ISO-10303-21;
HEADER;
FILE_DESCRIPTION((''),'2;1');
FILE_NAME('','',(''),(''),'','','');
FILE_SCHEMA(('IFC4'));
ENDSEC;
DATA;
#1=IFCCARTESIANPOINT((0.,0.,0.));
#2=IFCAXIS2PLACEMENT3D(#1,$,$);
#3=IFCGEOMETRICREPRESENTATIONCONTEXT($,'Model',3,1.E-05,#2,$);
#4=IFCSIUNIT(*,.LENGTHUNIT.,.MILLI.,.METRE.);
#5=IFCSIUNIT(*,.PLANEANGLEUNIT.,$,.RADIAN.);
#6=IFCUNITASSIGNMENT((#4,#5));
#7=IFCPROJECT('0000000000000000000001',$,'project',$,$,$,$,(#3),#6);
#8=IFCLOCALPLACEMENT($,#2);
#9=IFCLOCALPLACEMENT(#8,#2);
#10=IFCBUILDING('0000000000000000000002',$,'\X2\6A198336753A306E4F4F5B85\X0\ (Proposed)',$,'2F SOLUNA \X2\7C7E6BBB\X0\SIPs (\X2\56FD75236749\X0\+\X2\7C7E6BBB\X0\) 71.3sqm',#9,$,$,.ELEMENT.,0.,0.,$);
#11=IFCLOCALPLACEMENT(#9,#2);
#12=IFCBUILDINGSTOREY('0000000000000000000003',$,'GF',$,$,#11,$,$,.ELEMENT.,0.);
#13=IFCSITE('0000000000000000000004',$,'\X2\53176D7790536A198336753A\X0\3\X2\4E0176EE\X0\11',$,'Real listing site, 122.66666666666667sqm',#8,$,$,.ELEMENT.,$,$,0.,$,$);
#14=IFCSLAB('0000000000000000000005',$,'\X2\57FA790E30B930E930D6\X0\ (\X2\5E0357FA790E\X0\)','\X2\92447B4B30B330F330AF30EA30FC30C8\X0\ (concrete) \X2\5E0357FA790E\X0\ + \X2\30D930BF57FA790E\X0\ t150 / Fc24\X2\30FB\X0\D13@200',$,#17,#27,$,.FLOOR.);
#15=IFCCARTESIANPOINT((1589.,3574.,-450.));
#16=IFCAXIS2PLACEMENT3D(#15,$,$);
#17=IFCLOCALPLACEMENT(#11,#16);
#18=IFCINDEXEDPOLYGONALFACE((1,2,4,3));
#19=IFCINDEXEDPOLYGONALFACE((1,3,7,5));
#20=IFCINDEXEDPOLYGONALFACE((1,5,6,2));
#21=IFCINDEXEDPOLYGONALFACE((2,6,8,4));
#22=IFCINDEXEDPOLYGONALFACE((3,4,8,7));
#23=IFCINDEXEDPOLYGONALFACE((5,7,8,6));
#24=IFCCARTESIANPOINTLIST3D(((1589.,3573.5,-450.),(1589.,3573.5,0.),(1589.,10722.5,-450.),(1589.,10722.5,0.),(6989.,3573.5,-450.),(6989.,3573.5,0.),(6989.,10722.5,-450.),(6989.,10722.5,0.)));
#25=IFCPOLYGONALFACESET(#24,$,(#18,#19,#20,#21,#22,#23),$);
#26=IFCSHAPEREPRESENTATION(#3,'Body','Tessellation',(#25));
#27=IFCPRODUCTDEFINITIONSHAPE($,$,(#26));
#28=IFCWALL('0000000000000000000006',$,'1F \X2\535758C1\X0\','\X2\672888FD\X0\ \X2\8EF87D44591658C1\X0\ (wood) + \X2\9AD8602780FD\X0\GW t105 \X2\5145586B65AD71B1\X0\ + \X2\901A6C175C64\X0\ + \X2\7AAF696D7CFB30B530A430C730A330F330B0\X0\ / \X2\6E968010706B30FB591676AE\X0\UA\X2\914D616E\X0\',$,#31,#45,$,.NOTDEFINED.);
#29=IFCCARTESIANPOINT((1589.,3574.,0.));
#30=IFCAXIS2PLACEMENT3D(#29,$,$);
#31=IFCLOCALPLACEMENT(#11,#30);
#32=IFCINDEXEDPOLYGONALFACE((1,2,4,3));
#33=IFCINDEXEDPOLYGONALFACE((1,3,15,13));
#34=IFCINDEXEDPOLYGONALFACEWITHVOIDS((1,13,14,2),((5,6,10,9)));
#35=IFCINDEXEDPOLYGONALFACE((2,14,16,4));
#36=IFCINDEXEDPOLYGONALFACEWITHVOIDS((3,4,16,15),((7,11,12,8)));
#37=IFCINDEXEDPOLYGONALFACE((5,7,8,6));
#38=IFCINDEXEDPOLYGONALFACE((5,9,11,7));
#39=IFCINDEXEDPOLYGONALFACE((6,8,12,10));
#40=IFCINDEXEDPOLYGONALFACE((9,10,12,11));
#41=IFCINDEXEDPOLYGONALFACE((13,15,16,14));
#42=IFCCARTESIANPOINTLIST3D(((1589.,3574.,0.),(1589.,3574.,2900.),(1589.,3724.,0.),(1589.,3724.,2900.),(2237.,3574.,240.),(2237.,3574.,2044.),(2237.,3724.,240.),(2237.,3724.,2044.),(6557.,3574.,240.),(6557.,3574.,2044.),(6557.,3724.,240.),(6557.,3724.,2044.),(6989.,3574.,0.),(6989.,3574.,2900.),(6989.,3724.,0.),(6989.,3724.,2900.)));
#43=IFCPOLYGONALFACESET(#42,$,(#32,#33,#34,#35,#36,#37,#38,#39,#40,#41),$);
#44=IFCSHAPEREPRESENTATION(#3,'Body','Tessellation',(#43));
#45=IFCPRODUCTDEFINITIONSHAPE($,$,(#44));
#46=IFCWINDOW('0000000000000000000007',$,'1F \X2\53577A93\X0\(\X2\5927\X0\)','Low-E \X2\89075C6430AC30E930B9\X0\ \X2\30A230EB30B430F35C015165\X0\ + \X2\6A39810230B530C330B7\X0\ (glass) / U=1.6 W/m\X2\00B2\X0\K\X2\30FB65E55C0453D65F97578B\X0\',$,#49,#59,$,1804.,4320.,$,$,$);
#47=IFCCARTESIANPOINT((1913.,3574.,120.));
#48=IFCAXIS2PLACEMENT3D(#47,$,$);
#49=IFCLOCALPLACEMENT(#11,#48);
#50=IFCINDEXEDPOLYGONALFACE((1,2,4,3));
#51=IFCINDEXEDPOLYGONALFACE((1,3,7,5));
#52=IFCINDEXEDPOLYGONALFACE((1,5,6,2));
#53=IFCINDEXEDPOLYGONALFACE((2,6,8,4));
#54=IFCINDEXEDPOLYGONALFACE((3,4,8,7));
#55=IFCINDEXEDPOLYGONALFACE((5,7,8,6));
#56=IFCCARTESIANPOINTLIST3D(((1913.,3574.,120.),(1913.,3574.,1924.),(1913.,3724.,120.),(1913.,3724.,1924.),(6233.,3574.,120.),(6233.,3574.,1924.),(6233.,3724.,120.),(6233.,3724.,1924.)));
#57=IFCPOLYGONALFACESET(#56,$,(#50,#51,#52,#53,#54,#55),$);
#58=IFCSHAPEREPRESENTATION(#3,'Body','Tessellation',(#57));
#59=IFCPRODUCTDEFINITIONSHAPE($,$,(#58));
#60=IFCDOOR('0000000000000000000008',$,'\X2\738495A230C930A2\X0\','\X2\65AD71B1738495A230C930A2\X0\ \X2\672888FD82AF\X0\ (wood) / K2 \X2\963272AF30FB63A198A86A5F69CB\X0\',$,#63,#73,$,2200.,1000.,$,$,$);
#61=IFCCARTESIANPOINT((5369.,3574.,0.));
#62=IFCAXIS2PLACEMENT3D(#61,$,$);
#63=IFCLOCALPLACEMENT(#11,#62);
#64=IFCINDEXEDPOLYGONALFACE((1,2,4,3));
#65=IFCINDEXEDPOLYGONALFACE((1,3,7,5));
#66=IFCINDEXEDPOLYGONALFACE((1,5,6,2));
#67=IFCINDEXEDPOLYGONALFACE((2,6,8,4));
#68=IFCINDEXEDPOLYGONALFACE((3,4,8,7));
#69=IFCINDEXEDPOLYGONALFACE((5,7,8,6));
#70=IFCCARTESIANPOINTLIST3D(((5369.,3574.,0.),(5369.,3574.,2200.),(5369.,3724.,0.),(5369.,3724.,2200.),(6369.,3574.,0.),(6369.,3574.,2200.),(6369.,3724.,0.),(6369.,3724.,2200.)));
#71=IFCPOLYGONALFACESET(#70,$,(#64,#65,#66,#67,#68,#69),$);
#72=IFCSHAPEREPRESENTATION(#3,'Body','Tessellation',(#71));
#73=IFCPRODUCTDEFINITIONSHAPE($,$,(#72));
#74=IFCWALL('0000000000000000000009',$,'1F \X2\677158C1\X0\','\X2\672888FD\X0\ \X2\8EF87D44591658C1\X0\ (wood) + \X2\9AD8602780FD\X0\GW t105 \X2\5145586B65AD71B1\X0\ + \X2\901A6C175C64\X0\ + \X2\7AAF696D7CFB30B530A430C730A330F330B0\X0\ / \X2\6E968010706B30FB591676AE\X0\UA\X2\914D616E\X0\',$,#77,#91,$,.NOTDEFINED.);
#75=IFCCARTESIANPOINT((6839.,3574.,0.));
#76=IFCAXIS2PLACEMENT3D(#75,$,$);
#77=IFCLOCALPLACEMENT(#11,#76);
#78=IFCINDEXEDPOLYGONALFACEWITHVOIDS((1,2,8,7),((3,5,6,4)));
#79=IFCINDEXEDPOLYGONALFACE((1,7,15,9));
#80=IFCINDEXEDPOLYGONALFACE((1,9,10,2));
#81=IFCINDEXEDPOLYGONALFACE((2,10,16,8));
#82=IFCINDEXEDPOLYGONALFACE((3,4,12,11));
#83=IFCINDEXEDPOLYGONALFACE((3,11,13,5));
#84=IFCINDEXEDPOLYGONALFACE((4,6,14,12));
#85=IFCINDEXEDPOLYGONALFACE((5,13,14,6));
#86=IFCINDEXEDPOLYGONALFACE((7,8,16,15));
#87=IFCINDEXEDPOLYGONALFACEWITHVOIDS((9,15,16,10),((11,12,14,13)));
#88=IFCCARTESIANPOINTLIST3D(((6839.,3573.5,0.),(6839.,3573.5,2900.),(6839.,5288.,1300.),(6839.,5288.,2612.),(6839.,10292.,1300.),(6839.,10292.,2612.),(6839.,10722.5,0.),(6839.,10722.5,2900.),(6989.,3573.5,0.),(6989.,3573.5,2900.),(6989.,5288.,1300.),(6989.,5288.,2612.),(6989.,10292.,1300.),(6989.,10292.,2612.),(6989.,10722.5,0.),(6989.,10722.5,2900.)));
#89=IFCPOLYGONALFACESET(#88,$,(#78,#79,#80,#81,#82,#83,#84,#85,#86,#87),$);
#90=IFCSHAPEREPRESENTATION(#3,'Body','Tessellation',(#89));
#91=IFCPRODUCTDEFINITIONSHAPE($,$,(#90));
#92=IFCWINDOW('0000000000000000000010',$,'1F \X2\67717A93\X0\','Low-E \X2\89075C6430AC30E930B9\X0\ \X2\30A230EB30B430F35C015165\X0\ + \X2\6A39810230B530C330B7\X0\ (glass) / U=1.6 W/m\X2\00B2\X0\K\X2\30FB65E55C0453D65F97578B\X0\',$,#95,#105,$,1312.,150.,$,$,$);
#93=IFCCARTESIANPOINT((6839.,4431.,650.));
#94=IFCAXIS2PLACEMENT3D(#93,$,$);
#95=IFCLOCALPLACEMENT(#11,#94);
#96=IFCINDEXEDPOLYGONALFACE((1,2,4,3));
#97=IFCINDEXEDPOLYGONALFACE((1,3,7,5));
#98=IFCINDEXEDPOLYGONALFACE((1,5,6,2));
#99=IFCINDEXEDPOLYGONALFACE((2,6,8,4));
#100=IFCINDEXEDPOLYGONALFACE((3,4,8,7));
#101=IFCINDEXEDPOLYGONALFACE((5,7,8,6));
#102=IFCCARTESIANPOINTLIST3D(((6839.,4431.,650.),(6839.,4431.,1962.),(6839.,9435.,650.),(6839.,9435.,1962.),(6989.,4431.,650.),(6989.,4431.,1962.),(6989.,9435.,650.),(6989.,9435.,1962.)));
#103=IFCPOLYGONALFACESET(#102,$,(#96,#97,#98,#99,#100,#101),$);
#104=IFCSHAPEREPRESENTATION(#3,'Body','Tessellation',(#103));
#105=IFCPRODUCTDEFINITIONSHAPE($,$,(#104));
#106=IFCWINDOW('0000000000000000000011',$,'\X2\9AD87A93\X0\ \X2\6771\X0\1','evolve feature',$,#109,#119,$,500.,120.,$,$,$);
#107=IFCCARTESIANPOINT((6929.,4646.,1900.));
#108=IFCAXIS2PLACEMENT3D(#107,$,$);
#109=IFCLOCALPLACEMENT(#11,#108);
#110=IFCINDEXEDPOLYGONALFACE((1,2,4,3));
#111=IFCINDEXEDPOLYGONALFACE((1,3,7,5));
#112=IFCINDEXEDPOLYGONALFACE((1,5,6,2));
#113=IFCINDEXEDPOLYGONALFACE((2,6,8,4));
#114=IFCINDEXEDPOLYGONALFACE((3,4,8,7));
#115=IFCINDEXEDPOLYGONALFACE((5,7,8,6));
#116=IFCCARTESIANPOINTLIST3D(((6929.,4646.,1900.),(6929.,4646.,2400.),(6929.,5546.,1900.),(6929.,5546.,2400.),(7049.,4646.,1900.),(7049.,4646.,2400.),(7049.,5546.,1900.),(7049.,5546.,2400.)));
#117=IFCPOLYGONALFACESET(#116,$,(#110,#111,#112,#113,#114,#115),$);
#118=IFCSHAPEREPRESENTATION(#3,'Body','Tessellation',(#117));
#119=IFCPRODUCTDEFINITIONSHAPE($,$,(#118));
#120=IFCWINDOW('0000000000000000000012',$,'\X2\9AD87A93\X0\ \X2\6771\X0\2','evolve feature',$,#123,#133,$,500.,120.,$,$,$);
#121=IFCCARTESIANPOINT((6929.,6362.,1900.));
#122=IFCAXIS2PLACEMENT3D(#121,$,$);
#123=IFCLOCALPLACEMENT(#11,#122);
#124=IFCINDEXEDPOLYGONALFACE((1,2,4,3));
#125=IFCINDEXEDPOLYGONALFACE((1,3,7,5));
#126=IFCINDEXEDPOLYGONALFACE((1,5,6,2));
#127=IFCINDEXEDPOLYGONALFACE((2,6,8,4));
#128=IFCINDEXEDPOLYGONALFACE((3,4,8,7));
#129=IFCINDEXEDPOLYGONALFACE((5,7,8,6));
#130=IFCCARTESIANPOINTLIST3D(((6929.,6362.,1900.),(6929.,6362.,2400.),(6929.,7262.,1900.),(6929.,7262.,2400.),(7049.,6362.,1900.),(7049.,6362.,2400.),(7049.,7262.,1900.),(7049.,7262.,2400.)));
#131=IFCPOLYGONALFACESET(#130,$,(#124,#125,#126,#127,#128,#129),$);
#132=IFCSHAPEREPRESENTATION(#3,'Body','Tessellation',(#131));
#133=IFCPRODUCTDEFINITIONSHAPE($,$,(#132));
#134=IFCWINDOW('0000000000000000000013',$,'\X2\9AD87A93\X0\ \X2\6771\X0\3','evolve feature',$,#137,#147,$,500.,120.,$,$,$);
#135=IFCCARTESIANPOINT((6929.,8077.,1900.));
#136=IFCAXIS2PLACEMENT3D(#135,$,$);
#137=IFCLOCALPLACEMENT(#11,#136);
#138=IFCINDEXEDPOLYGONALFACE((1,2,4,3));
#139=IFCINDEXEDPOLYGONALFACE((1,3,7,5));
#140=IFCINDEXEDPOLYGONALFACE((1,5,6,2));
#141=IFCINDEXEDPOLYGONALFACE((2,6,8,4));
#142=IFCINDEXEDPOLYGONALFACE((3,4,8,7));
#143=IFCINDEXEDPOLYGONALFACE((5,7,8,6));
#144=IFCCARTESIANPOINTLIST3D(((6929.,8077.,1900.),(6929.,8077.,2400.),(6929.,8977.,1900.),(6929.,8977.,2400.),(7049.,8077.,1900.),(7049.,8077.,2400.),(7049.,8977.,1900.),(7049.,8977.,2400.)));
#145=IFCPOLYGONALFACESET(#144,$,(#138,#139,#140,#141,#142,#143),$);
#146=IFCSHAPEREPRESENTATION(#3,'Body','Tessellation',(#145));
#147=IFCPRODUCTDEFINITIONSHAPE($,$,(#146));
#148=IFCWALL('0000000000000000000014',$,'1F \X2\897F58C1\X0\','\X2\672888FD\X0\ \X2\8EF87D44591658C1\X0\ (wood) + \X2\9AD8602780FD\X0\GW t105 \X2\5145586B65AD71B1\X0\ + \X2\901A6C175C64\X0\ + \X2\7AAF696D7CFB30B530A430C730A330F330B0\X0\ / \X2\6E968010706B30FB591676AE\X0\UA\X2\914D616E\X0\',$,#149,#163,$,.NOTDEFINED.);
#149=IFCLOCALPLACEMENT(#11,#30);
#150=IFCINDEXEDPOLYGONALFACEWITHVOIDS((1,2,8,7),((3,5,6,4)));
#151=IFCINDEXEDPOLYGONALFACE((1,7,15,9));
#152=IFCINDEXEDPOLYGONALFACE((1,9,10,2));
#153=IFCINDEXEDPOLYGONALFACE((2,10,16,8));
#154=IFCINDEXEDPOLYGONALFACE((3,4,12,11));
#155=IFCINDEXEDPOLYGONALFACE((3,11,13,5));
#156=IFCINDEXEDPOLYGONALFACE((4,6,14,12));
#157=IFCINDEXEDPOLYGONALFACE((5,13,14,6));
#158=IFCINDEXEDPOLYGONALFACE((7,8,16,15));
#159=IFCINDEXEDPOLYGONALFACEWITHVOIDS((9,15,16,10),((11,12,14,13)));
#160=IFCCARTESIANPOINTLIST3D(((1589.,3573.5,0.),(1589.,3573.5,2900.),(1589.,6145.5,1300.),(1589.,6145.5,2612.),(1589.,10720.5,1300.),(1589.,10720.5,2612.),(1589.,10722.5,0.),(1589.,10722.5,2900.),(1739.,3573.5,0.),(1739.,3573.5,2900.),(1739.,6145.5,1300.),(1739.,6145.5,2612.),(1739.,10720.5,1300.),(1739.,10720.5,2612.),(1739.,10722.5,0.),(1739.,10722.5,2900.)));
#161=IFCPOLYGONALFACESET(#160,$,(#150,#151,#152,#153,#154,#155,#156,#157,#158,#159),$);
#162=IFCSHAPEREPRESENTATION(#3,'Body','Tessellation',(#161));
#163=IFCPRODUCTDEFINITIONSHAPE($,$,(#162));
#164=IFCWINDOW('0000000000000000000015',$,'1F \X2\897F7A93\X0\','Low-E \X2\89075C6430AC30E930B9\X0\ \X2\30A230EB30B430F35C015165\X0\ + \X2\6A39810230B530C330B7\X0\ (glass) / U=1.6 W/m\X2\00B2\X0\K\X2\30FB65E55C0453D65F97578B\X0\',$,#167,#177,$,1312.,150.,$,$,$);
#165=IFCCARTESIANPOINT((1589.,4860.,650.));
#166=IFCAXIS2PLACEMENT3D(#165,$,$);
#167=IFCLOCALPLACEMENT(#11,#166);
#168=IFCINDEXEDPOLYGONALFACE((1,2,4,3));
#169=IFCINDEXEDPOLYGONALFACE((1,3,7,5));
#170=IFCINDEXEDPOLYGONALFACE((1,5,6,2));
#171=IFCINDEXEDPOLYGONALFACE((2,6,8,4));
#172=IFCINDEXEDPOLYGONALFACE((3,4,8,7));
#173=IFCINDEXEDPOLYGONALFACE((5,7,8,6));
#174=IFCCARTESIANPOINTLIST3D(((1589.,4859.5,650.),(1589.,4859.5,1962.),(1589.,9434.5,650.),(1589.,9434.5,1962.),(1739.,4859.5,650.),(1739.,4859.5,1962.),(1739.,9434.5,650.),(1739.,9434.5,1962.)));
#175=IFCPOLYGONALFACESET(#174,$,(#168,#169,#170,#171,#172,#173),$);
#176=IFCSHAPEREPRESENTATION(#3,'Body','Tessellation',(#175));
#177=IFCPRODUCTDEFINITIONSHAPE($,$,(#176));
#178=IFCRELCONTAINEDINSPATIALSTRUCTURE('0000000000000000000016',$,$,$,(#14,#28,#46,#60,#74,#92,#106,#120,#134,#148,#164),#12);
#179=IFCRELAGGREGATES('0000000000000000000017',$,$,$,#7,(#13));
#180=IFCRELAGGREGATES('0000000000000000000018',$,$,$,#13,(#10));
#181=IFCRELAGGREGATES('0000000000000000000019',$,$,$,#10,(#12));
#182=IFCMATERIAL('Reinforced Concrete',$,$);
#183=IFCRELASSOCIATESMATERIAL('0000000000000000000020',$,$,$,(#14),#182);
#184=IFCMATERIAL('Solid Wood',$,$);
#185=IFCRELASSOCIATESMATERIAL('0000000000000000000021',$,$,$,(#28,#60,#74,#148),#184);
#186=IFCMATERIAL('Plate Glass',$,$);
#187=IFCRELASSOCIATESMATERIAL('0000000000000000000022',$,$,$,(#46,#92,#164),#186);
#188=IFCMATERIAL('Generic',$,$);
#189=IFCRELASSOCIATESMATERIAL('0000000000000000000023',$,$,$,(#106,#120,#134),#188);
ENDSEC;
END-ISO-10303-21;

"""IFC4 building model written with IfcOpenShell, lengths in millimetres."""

from ifc_helpers import new_model, si_unit, frame, frame_2d, origin, place, context, project, spatial, rectangle, extrude, material, element, fill, save


model = new_model("IFC4")

# Units and contexts
model_context = context("Model", 3, precision=1e-05, world=origin())
ifc_project = project(units=[si_unit("LENGTHUNIT", "METRE", prefix="MILLI"), si_unit("PLANEANGLEUNIT", "RADIAN")], contexts=[model_context])

# Site, building, storey
site_placement = place(None, origin())
site = spatial("IfcSite", under=ifc_project, at=site_placement, Name="北海道標茶町3丁目11", ObjectType="Real listing site, 122.66666666666667sqm", CompositionType="ELEMENT", RefElevation=0.0)
building_placement = place(site_placement, origin())
building = spatial("IfcBuilding", under=site, at=building_placement, Name="標茶町の住宅 (Proposed)", ObjectType="2F SOLUNA 籾殻SIPs (国産杉+籾殻) 71.3sqm", CompositionType="ELEMENT", ElevationOfRefHeight=0.0, ElevationOfTerrain=0.0)
storey_placement = place(building_placement, origin())
storey = spatial("IfcBuildingStorey", under=building, at=storey_placement, Name="GF", CompositionType="ELEMENT", Elevation=0.0)

# Slab
ifc_material_1 = material(Name="Reinforced Concrete")
slab_1_placement = place(storey_placement, frame((1589.0, 3574.0, -450.0)))
element("IfcSlab", 1, at=slab_1_placement, inside=storey, material=ifc_material_1, Name="基礎スラブ (布基礎)", Description="鉄筋コンクリート (concrete) 布基礎 + ベタ基礎 t150 / Fc24・D13@200", PredefinedType="FLOOR", context=model_context, shape_type="SweptSolid", body=[
    extrude(rectangle(XDim=5400.0, YDim=7149.0, at=frame_2d((2700.0, 3574.0))), frame((1589.0, 3574.0, -450.0)), (0.0, 0.0, 1.0), 450.0),
])
ifc_material_2 = material(Name="Solid Wood")

# Wall, openings, window, door
wall_1_placement = place(storey_placement, frame((1589.0, 3574.0, 0.0)))
wall_1 = element("IfcWall", 2, at=wall_1_placement, inside=storey, material=ifc_material_2, Name="1F 南壁", Description="木製 軸組外壁 (wood) + 高性能GW t105 充填断熱 + 通気層 + 窯業系サイディング / 準耐火・外皮UA配慮", PredefinedType="NOTDEFINED", context=model_context, shape_type="SweptSolid", body=[
    extrude(rectangle(XDim=5400.0, YDim=150.0, at=frame_2d((2700.0, 75.0))), frame((1589.0, 3574.0, 0.0)), (0.0, 0.0, 1.0), 2900.0),
])
opening_1_placement = place(storey_placement, frame((1913.0, 3574.0, 120.0)))
opening_1 = element("IfcOpeningElement", 3, at=opening_1_placement, cuts=wall_1, PredefinedType="NOTDEFINED", context=model_context, shape_type="SweptSolid", body=[
    extrude(rectangle(XDim=4320.0, YDim=150.0, at=frame_2d((2160.0, 75.0))), frame((1913.0, 3574.0, 120.0)), (0.0, 0.0, 1.0), 1804.0),
])
opening_2_placement = place(storey_placement, frame((5369.0, 3574.0, 0.0)))
opening_2 = element("IfcOpeningElement", 4, at=opening_2_placement, cuts=wall_1, PredefinedType="NOTDEFINED", context=model_context, shape_type="SweptSolid", body=[
    extrude(rectangle(XDim=1000.0, YDim=150.0, at=frame_2d((500.0, 75.0))), frame((5369.0, 3574.0, 0.0)), (0.0, 0.0, 1.0), 2200.0),
])
ifc_material_3 = material(Name="Plate Glass")
window_1_placement = place(storey_placement, frame((1913.0, 3574.0, 120.0)))
window_1 = element("IfcWindow", 5, at=window_1_placement, inside=storey, material=ifc_material_3, Name="1F 南窓(大)", Description="Low-E 複層ガラス アルゴン封入 + 樹脂サッシ (glass) / U=1.6 W/m²K・日射取得型", OverallHeight=1804.0, OverallWidth=4320.0, context=model_context, shape_type="SweptSolid", body=[
    extrude(rectangle(XDim=4320.0, YDim=150.0, at=frame_2d((2160.0, 75.0))), frame((1913.0, 3574.0, 120.0)), (0.0, 0.0, 1.0), 1804.0),
])
fill(opening_1, window_1)
door_placement = place(storey_placement, frame((5369.0, 3574.0, 0.0)))
door = element("IfcDoor", 6, at=door_placement, inside=storey, material=ifc_material_2, Name="玄関ドア", Description="断熱玄関ドア 木製芯 (wood) / K2 防犯・採風機構", OverallHeight=2200.0, OverallWidth=1000.0, context=model_context, shape_type="SweptSolid", body=[
    extrude(rectangle(XDim=1000.0, YDim=150.0, at=frame_2d((500.0, 75.0))), frame((5369.0, 3574.0, 0.0)), (0.0, 0.0, 1.0), 2200.0),
])
fill(opening_2, door)

# Wall, openings, windows
wall_2_placement = place(storey_placement, frame((6839.0, 3574.0, 0.0)))
wall_2 = element("IfcWall", 7, at=wall_2_placement, inside=storey, material=ifc_material_2, Name="1F 東壁", Description="木製 軸組外壁 (wood) + 高性能GW t105 充填断熱 + 通気層 + 窯業系サイディング / 準耐火・外皮UA配慮", PredefinedType="NOTDEFINED", context=model_context, shape_type="SweptSolid", body=[
    extrude(rectangle(XDim=150.0, YDim=7149.0, at=frame_2d((75.0, 3574.0))), frame((6839.0, 3574.0, 0.0)), (0.0, 0.0, 1.0), 2900.0),
])
opening_3_placement = place(storey_placement, frame((6839.0, 4431.0, 650.0)))
opening_3 = element("IfcOpeningElement", 8, at=opening_3_placement, cuts=wall_2, PredefinedType="NOTDEFINED", context=model_context, shape_type="SweptSolid", body=[
    extrude(rectangle(XDim=150.0, YDim=5004.0, at=frame_2d((75.0, 2502.0))), frame((6839.0, 4431.0, 650.0)), (0.0, 0.0, 1.0), 1312.0),
])
opening_4_placement = place(storey_placement, frame((6929.0, 4646.0, 1900.0)))
opening_4 = element("IfcOpeningElement", 9, at=opening_4_placement, cuts=wall_2, PredefinedType="NOTDEFINED", context=model_context, shape_type="SweptSolid", body=[
    extrude(rectangle(XDim=120.0, YDim=900.0, at=frame_2d((60.0, 450.0))), frame((6929.0, 4646.0, 1900.0)), (0.0, 0.0, 1.0), 500.0),
])
opening_5_placement = place(storey_placement, frame((6929.0, 6362.0, 1900.0)))
opening_5 = element("IfcOpeningElement", 10, at=opening_5_placement, cuts=wall_2, PredefinedType="NOTDEFINED", context=model_context, shape_type="SweptSolid", body=[
    extrude(rectangle(XDim=120.0, YDim=900.0, at=frame_2d((60.0, 450.0))), frame((6929.0, 6362.0, 1900.0)), (0.0, 0.0, 1.0), 500.0),
])
opening_6_placement = place(storey_placement, frame((6929.0, 8077.0, 1900.0)))
opening_6 = element("IfcOpeningElement", 11, at=opening_6_placement, cuts=wall_2, PredefinedType="NOTDEFINED", context=model_context, shape_type="SweptSolid", body=[
    extrude(rectangle(XDim=120.0, YDim=900.0, at=frame_2d((60.0, 450.0))), frame((6929.0, 8077.0, 1900.0)), (0.0, 0.0, 1.0), 500.0),
])
window_2_placement = place(storey_placement, frame((6839.0, 4431.0, 650.0)))
window_2 = element("IfcWindow", 12, at=window_2_placement, inside=storey, material=ifc_material_3, Name="1F 東窓", Description="Low-E 複層ガラス アルゴン封入 + 樹脂サッシ (glass) / U=1.6 W/m²K・日射取得型", OverallHeight=1312.0, OverallWidth=150.0, context=model_context, shape_type="SweptSolid", body=[
    extrude(rectangle(XDim=150.0, YDim=5004.0, at=frame_2d((75.0, 2502.0))), frame((6839.0, 4431.0, 650.0)), (0.0, 0.0, 1.0), 1312.0),
])
fill(opening_3, window_2)
ifc_material_4 = material(Name="Generic")
window_3_placement = place(storey_placement, frame((6929.0, 4646.0, 1900.0)))
window_3 = element("IfcWindow", 13, at=window_3_placement, inside=storey, material=ifc_material_4, Name="高窓 東1", Description="evolve feature", OverallHeight=500.0, OverallWidth=120.0, context=model_context, shape_type="SweptSolid", body=[
    extrude(rectangle(XDim=120.0, YDim=900.0, at=frame_2d((60.0, 450.0))), frame((6929.0, 4646.0, 1900.0)), (0.0, 0.0, 1.0), 500.0),
])
fill(opening_4, window_3)
window_4_placement = place(storey_placement, frame((6929.0, 6362.0, 1900.0)))
window_4 = element("IfcWindow", 14, at=window_4_placement, inside=storey, material=ifc_material_4, Name="高窓 東2", Description="evolve feature", OverallHeight=500.0, OverallWidth=120.0, context=model_context, shape_type="SweptSolid", body=[
    extrude(rectangle(XDim=120.0, YDim=900.0, at=frame_2d((60.0, 450.0))), frame((6929.0, 6362.0, 1900.0)), (0.0, 0.0, 1.0), 500.0),
])
fill(opening_5, window_4)
window_5_placement = place(storey_placement, frame((6929.0, 8077.0, 1900.0)))
window_5 = element("IfcWindow", 15, at=window_5_placement, inside=storey, material=ifc_material_4, Name="高窓 東3", Description="evolve feature", OverallHeight=500.0, OverallWidth=120.0, context=model_context, shape_type="SweptSolid", body=[
    extrude(rectangle(XDim=120.0, YDim=900.0, at=frame_2d((60.0, 450.0))), frame((6929.0, 8077.0, 1900.0)), (0.0, 0.0, 1.0), 500.0),
])
fill(opening_6, window_5)

# Wall, opening, window
wall_3_placement = place(storey_placement, frame((1589.0, 3574.0, 0.0)))
wall_3 = element("IfcWall", 16, at=wall_3_placement, inside=storey, material=ifc_material_2, Name="1F 西壁", Description="木製 軸組外壁 (wood) + 高性能GW t105 充填断熱 + 通気層 + 窯業系サイディング / 準耐火・外皮UA配慮", PredefinedType="NOTDEFINED", context=model_context, shape_type="SweptSolid", body=[
    extrude(rectangle(XDim=150.0, YDim=7149.0, at=frame_2d((75.0, 3574.0))), frame((1589.0, 3574.0, 0.0)), (0.0, 0.0, 1.0), 2900.0),
])
opening_7_placement = place(storey_placement, frame((1589.0, 4860.0, 650.0)))
opening_7 = element("IfcOpeningElement", 17, at=opening_7_placement, cuts=wall_3, PredefinedType="NOTDEFINED", context=model_context, shape_type="SweptSolid", body=[
    extrude(rectangle(XDim=150.0, YDim=4575.0, at=frame_2d((75.0, 2287.0))), frame((1589.0, 4860.0, 650.0)), (0.0, 0.0, 1.0), 1312.0),
])
window_6_placement = place(storey_placement, frame((1589.0, 4860.0, 650.0)))
window_6 = element("IfcWindow", 18, at=window_6_placement, inside=storey, material=ifc_material_3, Name="1F 西窓", Description="Low-E 複層ガラス アルゴン封入 + 樹脂サッシ (glass) / U=1.6 W/m²K・日射取得型", OverallHeight=1312.0, OverallWidth=150.0, context=model_context, shape_type="SweptSolid", body=[
    extrude(rectangle(XDim=150.0, YDim=4575.0, at=frame_2d((75.0, 2287.0))), frame((1589.0, 4860.0, 650.0)), (0.0, 0.0, 1.0), 1312.0),
])
fill(opening_7, window_6)

save(model, "model.ifc")
